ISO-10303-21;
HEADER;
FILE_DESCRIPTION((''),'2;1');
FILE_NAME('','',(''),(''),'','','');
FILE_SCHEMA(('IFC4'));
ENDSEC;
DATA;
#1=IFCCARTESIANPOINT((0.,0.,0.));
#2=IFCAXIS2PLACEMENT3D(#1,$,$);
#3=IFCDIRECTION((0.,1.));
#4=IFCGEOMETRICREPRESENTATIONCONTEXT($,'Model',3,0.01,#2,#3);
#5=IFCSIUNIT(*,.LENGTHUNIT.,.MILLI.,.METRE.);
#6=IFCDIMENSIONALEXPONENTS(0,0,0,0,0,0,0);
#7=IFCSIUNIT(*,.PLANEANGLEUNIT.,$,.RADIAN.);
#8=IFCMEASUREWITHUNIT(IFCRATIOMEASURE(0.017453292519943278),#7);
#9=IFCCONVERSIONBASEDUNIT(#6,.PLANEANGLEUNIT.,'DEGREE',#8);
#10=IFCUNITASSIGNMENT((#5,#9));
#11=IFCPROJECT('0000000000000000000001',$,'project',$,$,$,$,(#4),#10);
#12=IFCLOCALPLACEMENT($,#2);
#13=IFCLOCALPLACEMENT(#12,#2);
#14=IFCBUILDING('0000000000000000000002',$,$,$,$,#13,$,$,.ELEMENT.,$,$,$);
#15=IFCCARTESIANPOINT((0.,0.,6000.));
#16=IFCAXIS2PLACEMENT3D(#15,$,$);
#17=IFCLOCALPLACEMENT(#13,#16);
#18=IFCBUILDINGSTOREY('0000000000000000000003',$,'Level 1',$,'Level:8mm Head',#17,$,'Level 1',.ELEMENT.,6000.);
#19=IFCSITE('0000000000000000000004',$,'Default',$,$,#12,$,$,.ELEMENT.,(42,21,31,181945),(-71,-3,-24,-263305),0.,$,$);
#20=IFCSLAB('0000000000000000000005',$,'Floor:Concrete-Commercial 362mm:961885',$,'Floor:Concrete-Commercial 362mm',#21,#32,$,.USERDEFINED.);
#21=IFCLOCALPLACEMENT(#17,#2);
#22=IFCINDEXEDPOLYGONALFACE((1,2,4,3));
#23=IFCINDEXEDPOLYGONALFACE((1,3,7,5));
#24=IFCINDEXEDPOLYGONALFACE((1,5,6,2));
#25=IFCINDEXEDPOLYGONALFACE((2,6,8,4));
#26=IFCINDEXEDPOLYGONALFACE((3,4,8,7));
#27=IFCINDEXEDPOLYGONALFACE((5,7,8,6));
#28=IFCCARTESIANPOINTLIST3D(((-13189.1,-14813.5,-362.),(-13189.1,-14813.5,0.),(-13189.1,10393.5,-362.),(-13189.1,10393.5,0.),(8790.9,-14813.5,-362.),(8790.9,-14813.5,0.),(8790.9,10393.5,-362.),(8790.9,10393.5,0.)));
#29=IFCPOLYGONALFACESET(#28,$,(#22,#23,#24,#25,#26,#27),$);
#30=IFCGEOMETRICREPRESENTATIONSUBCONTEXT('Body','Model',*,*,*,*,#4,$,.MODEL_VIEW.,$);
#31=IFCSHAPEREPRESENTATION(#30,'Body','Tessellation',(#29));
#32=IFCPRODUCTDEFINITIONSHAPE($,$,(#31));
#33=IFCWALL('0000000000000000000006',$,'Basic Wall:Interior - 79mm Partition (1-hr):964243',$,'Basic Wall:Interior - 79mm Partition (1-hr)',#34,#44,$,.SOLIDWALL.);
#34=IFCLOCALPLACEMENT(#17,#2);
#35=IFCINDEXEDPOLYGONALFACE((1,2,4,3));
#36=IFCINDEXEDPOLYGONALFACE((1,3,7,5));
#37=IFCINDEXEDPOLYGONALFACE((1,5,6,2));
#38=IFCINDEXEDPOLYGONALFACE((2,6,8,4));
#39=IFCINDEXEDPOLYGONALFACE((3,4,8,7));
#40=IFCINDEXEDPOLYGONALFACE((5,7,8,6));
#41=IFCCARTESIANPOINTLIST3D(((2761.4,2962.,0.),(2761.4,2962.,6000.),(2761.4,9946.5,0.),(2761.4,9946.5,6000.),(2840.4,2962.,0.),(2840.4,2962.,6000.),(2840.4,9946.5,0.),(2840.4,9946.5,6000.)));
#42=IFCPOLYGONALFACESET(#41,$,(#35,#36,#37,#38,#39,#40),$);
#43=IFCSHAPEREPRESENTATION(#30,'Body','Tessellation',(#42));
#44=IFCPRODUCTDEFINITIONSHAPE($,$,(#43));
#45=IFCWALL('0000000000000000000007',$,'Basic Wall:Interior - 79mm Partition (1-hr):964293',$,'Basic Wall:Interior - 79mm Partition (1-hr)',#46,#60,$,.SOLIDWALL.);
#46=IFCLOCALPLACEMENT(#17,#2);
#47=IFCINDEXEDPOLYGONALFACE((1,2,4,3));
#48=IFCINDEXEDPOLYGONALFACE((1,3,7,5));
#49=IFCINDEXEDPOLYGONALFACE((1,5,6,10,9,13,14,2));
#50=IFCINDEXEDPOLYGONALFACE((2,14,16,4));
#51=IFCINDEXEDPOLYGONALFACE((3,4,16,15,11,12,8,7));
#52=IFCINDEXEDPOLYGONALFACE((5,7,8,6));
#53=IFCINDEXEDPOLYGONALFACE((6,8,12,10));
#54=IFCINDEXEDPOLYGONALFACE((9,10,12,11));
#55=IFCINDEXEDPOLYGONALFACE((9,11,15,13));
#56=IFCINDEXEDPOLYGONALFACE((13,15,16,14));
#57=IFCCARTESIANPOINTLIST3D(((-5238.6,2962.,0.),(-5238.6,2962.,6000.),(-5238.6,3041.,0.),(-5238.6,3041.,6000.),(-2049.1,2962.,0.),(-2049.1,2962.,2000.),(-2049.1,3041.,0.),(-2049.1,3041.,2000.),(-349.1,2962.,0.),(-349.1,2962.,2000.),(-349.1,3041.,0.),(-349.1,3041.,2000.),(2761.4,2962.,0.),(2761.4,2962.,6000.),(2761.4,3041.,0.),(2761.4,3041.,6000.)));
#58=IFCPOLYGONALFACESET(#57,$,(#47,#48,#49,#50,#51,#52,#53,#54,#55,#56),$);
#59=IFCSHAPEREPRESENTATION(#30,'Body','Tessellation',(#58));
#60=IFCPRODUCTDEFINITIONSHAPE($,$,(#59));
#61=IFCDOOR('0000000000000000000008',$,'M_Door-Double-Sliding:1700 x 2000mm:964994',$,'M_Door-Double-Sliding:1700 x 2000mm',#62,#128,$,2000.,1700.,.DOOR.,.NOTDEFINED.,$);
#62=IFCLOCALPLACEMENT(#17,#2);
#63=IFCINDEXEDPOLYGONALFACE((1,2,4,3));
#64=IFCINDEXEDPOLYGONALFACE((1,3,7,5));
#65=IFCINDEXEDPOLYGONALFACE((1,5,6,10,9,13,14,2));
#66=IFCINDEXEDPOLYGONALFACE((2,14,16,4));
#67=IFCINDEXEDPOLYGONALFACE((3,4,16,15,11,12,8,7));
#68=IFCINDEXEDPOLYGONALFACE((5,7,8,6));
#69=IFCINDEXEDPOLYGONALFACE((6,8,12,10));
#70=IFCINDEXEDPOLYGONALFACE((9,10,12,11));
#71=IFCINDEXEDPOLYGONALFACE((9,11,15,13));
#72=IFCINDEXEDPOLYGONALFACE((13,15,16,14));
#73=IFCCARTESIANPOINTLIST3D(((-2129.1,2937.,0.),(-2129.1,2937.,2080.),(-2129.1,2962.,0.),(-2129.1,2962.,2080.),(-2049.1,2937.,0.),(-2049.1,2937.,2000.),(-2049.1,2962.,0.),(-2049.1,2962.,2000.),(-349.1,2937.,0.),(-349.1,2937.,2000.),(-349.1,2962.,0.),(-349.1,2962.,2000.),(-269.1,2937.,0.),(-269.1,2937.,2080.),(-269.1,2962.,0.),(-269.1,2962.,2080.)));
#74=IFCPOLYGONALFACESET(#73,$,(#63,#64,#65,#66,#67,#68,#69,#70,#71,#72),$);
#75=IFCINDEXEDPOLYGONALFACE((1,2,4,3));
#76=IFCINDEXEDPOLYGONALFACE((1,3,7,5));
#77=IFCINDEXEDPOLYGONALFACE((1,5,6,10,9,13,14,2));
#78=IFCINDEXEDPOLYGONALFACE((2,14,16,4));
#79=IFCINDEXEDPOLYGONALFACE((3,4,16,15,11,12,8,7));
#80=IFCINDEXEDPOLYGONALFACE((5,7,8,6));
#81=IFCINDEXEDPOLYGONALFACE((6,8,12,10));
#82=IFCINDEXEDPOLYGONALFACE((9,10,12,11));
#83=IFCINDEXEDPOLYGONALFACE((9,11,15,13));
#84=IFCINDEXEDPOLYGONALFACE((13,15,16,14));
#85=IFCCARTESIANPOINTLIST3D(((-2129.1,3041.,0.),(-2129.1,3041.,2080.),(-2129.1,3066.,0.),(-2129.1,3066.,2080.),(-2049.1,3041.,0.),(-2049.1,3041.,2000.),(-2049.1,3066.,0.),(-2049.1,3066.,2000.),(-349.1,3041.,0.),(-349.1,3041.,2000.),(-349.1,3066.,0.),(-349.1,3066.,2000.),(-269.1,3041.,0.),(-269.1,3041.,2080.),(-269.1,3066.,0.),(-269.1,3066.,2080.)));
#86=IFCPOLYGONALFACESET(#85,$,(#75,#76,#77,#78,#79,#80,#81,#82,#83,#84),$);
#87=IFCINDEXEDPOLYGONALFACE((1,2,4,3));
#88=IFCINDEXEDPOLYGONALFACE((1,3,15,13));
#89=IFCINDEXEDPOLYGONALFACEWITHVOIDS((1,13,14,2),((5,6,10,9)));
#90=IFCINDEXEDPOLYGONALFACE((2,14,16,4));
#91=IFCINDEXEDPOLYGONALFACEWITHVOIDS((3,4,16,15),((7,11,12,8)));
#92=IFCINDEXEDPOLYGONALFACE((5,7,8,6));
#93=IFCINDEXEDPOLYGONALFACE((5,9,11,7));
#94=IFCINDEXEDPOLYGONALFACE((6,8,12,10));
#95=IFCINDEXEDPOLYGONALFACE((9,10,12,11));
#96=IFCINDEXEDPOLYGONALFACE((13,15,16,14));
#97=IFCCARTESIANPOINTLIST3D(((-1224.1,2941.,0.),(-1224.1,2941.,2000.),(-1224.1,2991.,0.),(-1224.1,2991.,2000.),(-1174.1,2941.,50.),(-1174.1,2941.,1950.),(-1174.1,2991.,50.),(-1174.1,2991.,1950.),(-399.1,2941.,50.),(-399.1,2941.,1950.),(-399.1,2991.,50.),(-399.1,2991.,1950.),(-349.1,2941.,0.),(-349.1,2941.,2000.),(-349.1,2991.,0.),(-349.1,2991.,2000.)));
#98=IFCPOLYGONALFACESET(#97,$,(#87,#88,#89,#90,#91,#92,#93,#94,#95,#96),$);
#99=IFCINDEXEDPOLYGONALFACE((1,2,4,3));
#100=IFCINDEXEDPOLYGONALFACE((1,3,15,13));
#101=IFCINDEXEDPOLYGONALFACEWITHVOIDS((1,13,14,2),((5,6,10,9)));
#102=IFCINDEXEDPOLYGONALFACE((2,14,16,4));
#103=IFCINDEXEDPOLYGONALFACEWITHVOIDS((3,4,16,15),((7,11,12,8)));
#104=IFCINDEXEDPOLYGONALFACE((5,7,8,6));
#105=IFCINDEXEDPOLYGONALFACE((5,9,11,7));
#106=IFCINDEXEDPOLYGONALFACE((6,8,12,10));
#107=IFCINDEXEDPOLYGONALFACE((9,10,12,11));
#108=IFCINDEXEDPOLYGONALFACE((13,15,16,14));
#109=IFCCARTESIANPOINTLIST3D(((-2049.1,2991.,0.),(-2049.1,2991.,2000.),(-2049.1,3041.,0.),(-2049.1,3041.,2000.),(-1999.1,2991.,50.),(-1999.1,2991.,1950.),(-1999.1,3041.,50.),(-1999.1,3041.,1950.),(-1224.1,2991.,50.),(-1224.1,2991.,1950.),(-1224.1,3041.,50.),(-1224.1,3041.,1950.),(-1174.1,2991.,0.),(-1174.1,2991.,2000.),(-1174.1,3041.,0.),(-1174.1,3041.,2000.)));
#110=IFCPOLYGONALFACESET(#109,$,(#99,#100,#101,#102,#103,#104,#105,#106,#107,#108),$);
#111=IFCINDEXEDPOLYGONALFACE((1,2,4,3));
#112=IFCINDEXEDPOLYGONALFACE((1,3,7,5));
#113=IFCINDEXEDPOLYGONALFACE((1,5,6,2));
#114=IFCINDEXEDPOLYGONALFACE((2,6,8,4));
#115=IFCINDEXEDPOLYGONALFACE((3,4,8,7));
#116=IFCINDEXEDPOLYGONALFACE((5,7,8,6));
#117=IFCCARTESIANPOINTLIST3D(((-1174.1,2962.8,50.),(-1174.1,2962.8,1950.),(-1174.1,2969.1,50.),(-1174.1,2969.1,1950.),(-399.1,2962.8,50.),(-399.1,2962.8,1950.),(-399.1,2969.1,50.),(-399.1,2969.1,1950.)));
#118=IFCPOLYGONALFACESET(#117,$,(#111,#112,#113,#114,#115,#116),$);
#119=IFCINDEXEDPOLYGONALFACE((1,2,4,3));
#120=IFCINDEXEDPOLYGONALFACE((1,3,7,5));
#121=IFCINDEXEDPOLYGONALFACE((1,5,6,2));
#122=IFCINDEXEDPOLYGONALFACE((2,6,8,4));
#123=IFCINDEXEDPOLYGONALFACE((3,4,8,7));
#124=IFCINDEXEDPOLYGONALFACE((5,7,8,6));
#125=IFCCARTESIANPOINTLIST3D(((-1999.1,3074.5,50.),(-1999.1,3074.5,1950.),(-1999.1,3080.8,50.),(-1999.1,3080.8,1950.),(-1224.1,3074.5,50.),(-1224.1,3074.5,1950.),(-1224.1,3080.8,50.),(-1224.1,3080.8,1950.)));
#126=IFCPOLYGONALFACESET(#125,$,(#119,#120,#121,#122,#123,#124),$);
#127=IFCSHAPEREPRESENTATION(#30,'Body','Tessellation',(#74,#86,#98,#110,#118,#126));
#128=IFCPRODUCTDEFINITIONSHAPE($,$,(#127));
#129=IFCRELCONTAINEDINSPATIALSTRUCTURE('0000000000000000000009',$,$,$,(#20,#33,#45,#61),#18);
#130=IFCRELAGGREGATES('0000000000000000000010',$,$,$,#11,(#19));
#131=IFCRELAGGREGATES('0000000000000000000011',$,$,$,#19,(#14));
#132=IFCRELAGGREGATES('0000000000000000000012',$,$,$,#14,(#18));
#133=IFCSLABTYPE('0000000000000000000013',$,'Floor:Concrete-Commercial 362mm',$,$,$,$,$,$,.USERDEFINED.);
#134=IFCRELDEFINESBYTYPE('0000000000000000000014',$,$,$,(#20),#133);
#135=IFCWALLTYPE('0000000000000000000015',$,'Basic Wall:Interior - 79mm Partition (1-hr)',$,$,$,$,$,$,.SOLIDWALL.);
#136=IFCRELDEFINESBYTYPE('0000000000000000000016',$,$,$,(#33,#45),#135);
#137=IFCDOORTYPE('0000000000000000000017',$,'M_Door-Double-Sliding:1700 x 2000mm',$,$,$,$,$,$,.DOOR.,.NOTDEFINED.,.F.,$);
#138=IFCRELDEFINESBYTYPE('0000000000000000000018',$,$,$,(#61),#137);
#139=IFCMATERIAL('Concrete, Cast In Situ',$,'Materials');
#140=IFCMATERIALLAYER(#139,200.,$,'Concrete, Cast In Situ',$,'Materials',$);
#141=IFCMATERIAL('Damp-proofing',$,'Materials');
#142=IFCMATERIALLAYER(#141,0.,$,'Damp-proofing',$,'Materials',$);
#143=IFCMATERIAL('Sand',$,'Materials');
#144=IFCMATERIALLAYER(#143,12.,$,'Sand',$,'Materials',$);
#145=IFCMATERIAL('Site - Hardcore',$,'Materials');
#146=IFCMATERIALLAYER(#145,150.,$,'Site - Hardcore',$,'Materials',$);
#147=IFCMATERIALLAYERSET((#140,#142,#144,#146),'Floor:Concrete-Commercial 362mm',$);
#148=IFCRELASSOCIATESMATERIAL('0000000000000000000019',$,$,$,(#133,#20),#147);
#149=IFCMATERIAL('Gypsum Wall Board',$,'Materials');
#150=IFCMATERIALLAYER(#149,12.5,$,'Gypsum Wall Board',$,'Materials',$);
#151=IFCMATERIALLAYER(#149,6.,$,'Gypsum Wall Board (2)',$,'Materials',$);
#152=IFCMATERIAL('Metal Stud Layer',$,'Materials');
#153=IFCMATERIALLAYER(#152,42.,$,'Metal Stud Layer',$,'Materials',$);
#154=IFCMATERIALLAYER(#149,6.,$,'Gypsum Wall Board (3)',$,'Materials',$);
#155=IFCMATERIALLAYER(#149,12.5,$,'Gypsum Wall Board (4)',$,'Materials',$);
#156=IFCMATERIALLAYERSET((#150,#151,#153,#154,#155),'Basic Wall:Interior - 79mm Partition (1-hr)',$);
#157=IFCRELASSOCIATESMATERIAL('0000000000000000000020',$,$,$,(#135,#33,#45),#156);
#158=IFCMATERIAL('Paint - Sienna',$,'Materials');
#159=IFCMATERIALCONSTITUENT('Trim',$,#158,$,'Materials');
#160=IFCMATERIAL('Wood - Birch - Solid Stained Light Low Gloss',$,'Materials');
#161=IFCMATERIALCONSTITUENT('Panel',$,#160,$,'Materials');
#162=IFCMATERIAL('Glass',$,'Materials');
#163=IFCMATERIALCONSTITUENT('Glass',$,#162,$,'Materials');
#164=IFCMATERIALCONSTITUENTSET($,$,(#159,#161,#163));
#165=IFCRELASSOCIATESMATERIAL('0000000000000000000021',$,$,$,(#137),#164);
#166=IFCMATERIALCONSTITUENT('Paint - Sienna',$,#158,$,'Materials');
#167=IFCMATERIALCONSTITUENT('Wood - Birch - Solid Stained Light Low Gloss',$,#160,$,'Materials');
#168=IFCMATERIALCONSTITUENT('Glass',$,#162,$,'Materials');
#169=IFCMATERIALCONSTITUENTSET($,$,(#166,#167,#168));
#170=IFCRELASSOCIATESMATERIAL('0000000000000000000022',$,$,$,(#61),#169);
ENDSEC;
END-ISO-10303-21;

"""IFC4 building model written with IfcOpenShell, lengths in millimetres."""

from ifc_helpers import new_model, entity, si_unit, converted_unit, direction, frame, frame_2d, origin, origin_2d_with_axis, place, context, subcontext, project, spatial, polyline, rectangle, outline, extrude, source, transform, mapped, material, layer, layer_set, layer_usage, constituent, constituent_set, type_object, type_shapes, element, fill, save


model = new_model("IFC4")

# Units and contexts
model_context = context("Model", 3, precision=0.01, world=origin(), true_north=direction((0.0, 1.0)))
body_context = subcontext(model_context, "Body", "Model", "MODEL_VIEW")
ifc_project = project(units=[si_unit("LENGTHUNIT", "METRE", prefix="MILLI"), converted_unit("PLANEANGLEUNIT", "DEGREE", entity("IfcRatioMeasure", 0.017453292519943278), si_unit("PLANEANGLEUNIT", "RADIAN"), dimensions=[0, 0, 0, 0, 0, 0, 0])], contexts=[model_context])

# Site, building, storey
site_placement = place(None, origin())
site = spatial("IfcSite", under=ifc_project, at=site_placement, Name="Default", CompositionType="ELEMENT", RefLatitude=(42, 21, 31, 181945), RefLongitude=(-71, -3, -24, -263305), RefElevation=0.0)
building_placement = place(site_placement, origin())
building = spatial("IfcBuilding", under=site, at=building_placement, CompositionType="ELEMENT")
storey_placement = place(building_placement, frame((0.0, 0.0, 6000.0)))
storey = spatial("IfcBuildingStorey", under=building, at=storey_placement, Name="Level 1", ObjectType="Level:8mm Head", LongName="Level 1", CompositionType="ELEMENT", Elevation=6000.0)

# Slab
ifc_material_1 = material(Name="Concrete, Cast In Situ", Category="Materials")
ifc_layer_1 = layer(ifc_material_1, 200.0, Name="Concrete, Cast In Situ", Category="Materials")
ifc_material_2 = material(Name="Damp-proofing", Category="Materials")
ifc_layer_2 = layer(ifc_material_2, 0.0, Name="Damp-proofing", Category="Materials")
ifc_material_3 = material(Name="Sand", Category="Materials")
ifc_layer_3 = layer(ifc_material_3, 12.0, Name="Sand", Category="Materials")
ifc_material_4 = material(Name="Site - Hardcore", Category="Materials")
ifc_layer_4 = layer(ifc_material_4, 150.0, Name="Site - Hardcore", Category="Materials")
ifc_layer_set_1 = layer_set([ifc_layer_1, ifc_layer_2, ifc_layer_3, ifc_layer_4], Name="Floor:Concrete-Commercial 362mm")
ifc_layer_usage_1 = layer_usage(ifc_layer_set_1, "AXIS3", "POSITIVE", 0.0)
slab_type = type_object("IfcSlabType", Name="Floor:Concrete-Commercial 362mm", PredefinedType="USERDEFINED", material=ifc_layer_set_1)
slab_placement = place(storey_placement, origin())
element("IfcSlab", 1, at=slab_placement, inside=storey, type_object=slab_type, material=ifc_layer_usage_1, Name="Floor:Concrete-Commercial 362mm:961885", ObjectType="Floor:Concrete-Commercial 362mm", PredefinedType="USERDEFINED", context=body_context, shape_type="SweptSolid", body=[
    extrude(rectangle(XDim=25207.0, YDim=21980.0, at=frame_2d((0.0, 0.0), x_axis=(1.0, 0.0))), frame((-2199.1, -2210.0, 0.0), z_axis=(0.0, 0.0, -1.0), x_axis=(0.0, 1.0, 0.0)), (0.0, 0.0, 1.0), 362.0),
])

# Wall
ifc_material_5 = material(Name="Gypsum Wall Board", Category="Materials")
ifc_layer_5 = layer(ifc_material_5, 12.5, Name="Gypsum Wall Board", Category="Materials")
ifc_layer_6 = layer(ifc_material_5, 6.0, Name="Gypsum Wall Board (2)", Category="Materials")
ifc_material_6 = material(Name="Metal Stud Layer", Category="Materials")
ifc_layer_7 = layer(ifc_material_6, 42.0, Name="Metal Stud Layer", Category="Materials")
ifc_layer_8 = layer(ifc_material_5, 6.0, Name="Gypsum Wall Board (3)", Category="Materials")
ifc_layer_9 = layer(ifc_material_5, 12.5, Name="Gypsum Wall Board (4)", Category="Materials")
ifc_layer_set_2 = layer_set([ifc_layer_5, ifc_layer_6, ifc_layer_7, ifc_layer_8, ifc_layer_9], Name="Basic Wall:Interior - 79mm Partition (1-hr)")
ifc_layer_usage_2 = layer_usage(ifc_layer_set_2, "AXIS2", "NEGATIVE", 39.5)
wall_type = type_object("IfcWallType", Name="Basic Wall:Interior - 79mm Partition (1-hr)", PredefinedType="SOLIDWALL", material=ifc_layer_set_2)
wall_1_placement = place(storey_placement, frame((2800.9, 9946.5, 0.0), z_axis=(0.0, 0.0, 1.0), x_axis=(0.0, -1.0, 0.0)))
element("IfcWall", 2, at=wall_1_placement, inside=storey, type_object=wall_type, material=ifc_layer_usage_2, Name="Basic Wall:Interior - 79mm Partition (1-hr):964243", ObjectType="Basic Wall:Interior - 79mm Partition (1-hr)", PredefinedType="SOLIDWALL", context=body_context, shape_type="SweptSolid", body=[
    extrude(rectangle(XDim=6984.5, YDim=79.0, at=frame_2d((3492.3, 0.0), x_axis=(-1.0, 0.0))), origin(), (0.0, 0.0, 1.0), 6000.0),
])

# Wall, opening, door
wall_2_placement = place(storey_placement, frame((2761.4, 3001.5, 0.0), z_axis=(0.0, 0.0, 1.0), x_axis=(-1.0, 0.0, 0.0)))
wall_2 = element("IfcWall", 3, at=wall_2_placement, inside=storey, type_object=wall_type, material=ifc_layer_usage_2, Name="Basic Wall:Interior - 79mm Partition (1-hr):964293", ObjectType="Basic Wall:Interior - 79mm Partition (1-hr)", PredefinedType="SOLIDWALL", context=body_context, shape_type="SweptSolid", body=[
    extrude(rectangle(XDim=8000.0, YDim=79.0, at=frame_2d((4000.0, 0.0), x_axis=(-1.0, 0.0))), origin(), (0.0, 0.0, 1.0), 6000.0),
])
opening_1_placement = place(wall_2_placement, frame((4810.5, 39.5, 0.0)))
opening_1 = element("IfcOpeningElement", 4, at=opening_1_placement, cuts=wall_2, PredefinedType="OPENING", context=body_context, shape_type="SweptSolid", body=[
    extrude(rectangle(XDim=2000.0, YDim=1700.0, at=frame_2d((1000.0, 850.0), x_axis=(-1.0, 0.0))), frame((0.0, 0.0, 0.0), z_axis=(0.0, -1.0, 0.0), x_axis=(0.0, 0.0, 1.0)), (0.0, 0.0, 1.0), 79.0),
])
ifc_material_7 = material(Name="Paint - Sienna", Category="Materials")
ifc_constituent_1 = constituent(ifc_material_7, Name="Paint - Sienna", Category="Materials")
ifc_material_8 = material(Name="Wood - Birch - Solid Stained Light Low Gloss", Category="Materials")
ifc_constituent_2 = constituent(ifc_material_8, Name="Wood - Birch - Solid Stained Light Low Gloss", Category="Materials")
ifc_material_9 = material(Name="Glass", Category="Materials")
ifc_constituent_3 = constituent(ifc_material_9, Name="Glass", Category="Materials")
ifc_constituent_set_1 = constituent_set(constituents=[ifc_constituent_1, ifc_constituent_2, ifc_constituent_3])
ifc_constituent_4 = constituent(ifc_material_7, Name="Trim", Category="Materials")
ifc_constituent_5 = constituent(ifc_material_8, Name="Panel", Category="Materials")
ifc_constituent_6 = constituent(ifc_material_9, Name="Glass", Category="Materials")
ifc_constituent_set_2 = constituent_set(constituents=[ifc_constituent_4, ifc_constituent_5, ifc_constituent_6])
door_type = type_object("IfcDoorType", Name="M_Door-Double-Sliding:1700 x 2000mm", OperationType="NOTDEFINED", ParameterTakesPrecedence=False, PredefinedType="DOOR", material=ifc_constituent_set_2)
shared_shape_1 = source(origin(), body_context, "Body", "SweptSolid", [
    extrude(outline(polyline([(-1020.0, -930.0), (1060.0, -930.0), (1060.0, 930.0), (-1020.0, 930.0), (-1020.0, 850.0), (980.0, 850.0), (980.0, -850.0), (-1020.0, -850.0), (-1020.0, -930.0)])), frame((850.0, -25.0, 1020.0), z_axis=(0.0, 1.0, 0.0), x_axis=(0.0, 0.0, 1.0)), (0.0, 0.0, 1.0), 25.0),
    extrude(outline(polyline([(-930.0, -1020.0), (-850.0, -1020.0), (-850.0, 980.0), (850.0, 980.0), (850.0, -1020.0), (930.0, -1020.0), (930.0, 1060.0), (-930.0, 1060.0), (-930.0, -1020.0)])), frame((850.0, 79.0, 1020.0), z_axis=(0.0, 1.0, 0.0), x_axis=(-1.0, 0.0, 0.0)), (0.0, 0.0, 1.0), 25.0),
    extrude(outline(polyline([(-437.5, -1000.0), (437.5, -1000.0), (437.5, 1000.0), (-437.5, 1000.0), (-437.5, -1000.0)]), holes=[polyline([(-387.5, -950.0), (-387.5, 950.0), (387.5, 950.0), (387.5, -950.0), (-387.5, -950.0)])]), frame((1262.5, -21.0, 1000.0), z_axis=(0.0, 1.0, 0.0), x_axis=(1.0, 0.0, 0.0)), (0.0, 0.0, 1.0), 50.0),
    extrude(outline(polyline([(-1000.0, -437.5), (1000.0, -437.5), (1000.0, 437.5), (-1000.0, 437.5), (-1000.0, -437.5)]), holes=[polyline([(-950.0, -387.5), (-950.0, 387.5), (950.0, 387.5), (950.0, -387.5), (-950.0, -387.5)])]), frame((437.5, 29.0, 1000.0), z_axis=(0.0, 1.0, 0.0), x_axis=(0.0, 0.0, -1.0)), (0.0, 0.0, 1.0), 50.0),
    extrude(rectangle(XDim=6.3, YDim=775.0, at=frame_2d((0.0, 0.0), x_axis=(1.0, 0.0))), frame((1262.5, 4.0, 50.0), z_axis=(0.0, 0.0, 1.0), x_axis=(0.0, -1.0, 0.0)), (0.0, 0.0, 1.0), 1900.0),
    extrude(rectangle(XDim=6.4, YDim=775.0, at=origin_2d_with_axis()), frame((437.5, 115.7, 50.0), z_axis=(0.0, 0.0, 1.0), x_axis=(0.0, 1.0, 0.0)), (0.0, 0.0, 1.0), 1900.0),
])
type_shapes(door_type, [shared_shape_1])
door_1_placement = place(opening_1_placement, frame((0.0, 0.0, 0.0), z_axis=(0.0, 0.0, 1.0), x_axis=(-1.0, 0.0, 0.0)))
door_1 = element("IfcDoor", 5, at=door_1_placement, inside=storey, type_object=door_type, material=ifc_constituent_set_1, Name="M_Door-Double-Sliding:1700 x 2000mm:964994", ObjectType="M_Door-Double-Sliding:1700 x 2000mm", OperationType="NOTDEFINED", OverallHeight=2000.0, OverallWidth=1700.0, PredefinedType="DOOR", context=body_context, shape_type="MappedRepresentation", body=[
    mapped(shared_shape_1, transform((0.0, 0.0, 0.0), scale=1.0)),
])
fill(opening_1, door_1)

save(model, "model.ifc")
